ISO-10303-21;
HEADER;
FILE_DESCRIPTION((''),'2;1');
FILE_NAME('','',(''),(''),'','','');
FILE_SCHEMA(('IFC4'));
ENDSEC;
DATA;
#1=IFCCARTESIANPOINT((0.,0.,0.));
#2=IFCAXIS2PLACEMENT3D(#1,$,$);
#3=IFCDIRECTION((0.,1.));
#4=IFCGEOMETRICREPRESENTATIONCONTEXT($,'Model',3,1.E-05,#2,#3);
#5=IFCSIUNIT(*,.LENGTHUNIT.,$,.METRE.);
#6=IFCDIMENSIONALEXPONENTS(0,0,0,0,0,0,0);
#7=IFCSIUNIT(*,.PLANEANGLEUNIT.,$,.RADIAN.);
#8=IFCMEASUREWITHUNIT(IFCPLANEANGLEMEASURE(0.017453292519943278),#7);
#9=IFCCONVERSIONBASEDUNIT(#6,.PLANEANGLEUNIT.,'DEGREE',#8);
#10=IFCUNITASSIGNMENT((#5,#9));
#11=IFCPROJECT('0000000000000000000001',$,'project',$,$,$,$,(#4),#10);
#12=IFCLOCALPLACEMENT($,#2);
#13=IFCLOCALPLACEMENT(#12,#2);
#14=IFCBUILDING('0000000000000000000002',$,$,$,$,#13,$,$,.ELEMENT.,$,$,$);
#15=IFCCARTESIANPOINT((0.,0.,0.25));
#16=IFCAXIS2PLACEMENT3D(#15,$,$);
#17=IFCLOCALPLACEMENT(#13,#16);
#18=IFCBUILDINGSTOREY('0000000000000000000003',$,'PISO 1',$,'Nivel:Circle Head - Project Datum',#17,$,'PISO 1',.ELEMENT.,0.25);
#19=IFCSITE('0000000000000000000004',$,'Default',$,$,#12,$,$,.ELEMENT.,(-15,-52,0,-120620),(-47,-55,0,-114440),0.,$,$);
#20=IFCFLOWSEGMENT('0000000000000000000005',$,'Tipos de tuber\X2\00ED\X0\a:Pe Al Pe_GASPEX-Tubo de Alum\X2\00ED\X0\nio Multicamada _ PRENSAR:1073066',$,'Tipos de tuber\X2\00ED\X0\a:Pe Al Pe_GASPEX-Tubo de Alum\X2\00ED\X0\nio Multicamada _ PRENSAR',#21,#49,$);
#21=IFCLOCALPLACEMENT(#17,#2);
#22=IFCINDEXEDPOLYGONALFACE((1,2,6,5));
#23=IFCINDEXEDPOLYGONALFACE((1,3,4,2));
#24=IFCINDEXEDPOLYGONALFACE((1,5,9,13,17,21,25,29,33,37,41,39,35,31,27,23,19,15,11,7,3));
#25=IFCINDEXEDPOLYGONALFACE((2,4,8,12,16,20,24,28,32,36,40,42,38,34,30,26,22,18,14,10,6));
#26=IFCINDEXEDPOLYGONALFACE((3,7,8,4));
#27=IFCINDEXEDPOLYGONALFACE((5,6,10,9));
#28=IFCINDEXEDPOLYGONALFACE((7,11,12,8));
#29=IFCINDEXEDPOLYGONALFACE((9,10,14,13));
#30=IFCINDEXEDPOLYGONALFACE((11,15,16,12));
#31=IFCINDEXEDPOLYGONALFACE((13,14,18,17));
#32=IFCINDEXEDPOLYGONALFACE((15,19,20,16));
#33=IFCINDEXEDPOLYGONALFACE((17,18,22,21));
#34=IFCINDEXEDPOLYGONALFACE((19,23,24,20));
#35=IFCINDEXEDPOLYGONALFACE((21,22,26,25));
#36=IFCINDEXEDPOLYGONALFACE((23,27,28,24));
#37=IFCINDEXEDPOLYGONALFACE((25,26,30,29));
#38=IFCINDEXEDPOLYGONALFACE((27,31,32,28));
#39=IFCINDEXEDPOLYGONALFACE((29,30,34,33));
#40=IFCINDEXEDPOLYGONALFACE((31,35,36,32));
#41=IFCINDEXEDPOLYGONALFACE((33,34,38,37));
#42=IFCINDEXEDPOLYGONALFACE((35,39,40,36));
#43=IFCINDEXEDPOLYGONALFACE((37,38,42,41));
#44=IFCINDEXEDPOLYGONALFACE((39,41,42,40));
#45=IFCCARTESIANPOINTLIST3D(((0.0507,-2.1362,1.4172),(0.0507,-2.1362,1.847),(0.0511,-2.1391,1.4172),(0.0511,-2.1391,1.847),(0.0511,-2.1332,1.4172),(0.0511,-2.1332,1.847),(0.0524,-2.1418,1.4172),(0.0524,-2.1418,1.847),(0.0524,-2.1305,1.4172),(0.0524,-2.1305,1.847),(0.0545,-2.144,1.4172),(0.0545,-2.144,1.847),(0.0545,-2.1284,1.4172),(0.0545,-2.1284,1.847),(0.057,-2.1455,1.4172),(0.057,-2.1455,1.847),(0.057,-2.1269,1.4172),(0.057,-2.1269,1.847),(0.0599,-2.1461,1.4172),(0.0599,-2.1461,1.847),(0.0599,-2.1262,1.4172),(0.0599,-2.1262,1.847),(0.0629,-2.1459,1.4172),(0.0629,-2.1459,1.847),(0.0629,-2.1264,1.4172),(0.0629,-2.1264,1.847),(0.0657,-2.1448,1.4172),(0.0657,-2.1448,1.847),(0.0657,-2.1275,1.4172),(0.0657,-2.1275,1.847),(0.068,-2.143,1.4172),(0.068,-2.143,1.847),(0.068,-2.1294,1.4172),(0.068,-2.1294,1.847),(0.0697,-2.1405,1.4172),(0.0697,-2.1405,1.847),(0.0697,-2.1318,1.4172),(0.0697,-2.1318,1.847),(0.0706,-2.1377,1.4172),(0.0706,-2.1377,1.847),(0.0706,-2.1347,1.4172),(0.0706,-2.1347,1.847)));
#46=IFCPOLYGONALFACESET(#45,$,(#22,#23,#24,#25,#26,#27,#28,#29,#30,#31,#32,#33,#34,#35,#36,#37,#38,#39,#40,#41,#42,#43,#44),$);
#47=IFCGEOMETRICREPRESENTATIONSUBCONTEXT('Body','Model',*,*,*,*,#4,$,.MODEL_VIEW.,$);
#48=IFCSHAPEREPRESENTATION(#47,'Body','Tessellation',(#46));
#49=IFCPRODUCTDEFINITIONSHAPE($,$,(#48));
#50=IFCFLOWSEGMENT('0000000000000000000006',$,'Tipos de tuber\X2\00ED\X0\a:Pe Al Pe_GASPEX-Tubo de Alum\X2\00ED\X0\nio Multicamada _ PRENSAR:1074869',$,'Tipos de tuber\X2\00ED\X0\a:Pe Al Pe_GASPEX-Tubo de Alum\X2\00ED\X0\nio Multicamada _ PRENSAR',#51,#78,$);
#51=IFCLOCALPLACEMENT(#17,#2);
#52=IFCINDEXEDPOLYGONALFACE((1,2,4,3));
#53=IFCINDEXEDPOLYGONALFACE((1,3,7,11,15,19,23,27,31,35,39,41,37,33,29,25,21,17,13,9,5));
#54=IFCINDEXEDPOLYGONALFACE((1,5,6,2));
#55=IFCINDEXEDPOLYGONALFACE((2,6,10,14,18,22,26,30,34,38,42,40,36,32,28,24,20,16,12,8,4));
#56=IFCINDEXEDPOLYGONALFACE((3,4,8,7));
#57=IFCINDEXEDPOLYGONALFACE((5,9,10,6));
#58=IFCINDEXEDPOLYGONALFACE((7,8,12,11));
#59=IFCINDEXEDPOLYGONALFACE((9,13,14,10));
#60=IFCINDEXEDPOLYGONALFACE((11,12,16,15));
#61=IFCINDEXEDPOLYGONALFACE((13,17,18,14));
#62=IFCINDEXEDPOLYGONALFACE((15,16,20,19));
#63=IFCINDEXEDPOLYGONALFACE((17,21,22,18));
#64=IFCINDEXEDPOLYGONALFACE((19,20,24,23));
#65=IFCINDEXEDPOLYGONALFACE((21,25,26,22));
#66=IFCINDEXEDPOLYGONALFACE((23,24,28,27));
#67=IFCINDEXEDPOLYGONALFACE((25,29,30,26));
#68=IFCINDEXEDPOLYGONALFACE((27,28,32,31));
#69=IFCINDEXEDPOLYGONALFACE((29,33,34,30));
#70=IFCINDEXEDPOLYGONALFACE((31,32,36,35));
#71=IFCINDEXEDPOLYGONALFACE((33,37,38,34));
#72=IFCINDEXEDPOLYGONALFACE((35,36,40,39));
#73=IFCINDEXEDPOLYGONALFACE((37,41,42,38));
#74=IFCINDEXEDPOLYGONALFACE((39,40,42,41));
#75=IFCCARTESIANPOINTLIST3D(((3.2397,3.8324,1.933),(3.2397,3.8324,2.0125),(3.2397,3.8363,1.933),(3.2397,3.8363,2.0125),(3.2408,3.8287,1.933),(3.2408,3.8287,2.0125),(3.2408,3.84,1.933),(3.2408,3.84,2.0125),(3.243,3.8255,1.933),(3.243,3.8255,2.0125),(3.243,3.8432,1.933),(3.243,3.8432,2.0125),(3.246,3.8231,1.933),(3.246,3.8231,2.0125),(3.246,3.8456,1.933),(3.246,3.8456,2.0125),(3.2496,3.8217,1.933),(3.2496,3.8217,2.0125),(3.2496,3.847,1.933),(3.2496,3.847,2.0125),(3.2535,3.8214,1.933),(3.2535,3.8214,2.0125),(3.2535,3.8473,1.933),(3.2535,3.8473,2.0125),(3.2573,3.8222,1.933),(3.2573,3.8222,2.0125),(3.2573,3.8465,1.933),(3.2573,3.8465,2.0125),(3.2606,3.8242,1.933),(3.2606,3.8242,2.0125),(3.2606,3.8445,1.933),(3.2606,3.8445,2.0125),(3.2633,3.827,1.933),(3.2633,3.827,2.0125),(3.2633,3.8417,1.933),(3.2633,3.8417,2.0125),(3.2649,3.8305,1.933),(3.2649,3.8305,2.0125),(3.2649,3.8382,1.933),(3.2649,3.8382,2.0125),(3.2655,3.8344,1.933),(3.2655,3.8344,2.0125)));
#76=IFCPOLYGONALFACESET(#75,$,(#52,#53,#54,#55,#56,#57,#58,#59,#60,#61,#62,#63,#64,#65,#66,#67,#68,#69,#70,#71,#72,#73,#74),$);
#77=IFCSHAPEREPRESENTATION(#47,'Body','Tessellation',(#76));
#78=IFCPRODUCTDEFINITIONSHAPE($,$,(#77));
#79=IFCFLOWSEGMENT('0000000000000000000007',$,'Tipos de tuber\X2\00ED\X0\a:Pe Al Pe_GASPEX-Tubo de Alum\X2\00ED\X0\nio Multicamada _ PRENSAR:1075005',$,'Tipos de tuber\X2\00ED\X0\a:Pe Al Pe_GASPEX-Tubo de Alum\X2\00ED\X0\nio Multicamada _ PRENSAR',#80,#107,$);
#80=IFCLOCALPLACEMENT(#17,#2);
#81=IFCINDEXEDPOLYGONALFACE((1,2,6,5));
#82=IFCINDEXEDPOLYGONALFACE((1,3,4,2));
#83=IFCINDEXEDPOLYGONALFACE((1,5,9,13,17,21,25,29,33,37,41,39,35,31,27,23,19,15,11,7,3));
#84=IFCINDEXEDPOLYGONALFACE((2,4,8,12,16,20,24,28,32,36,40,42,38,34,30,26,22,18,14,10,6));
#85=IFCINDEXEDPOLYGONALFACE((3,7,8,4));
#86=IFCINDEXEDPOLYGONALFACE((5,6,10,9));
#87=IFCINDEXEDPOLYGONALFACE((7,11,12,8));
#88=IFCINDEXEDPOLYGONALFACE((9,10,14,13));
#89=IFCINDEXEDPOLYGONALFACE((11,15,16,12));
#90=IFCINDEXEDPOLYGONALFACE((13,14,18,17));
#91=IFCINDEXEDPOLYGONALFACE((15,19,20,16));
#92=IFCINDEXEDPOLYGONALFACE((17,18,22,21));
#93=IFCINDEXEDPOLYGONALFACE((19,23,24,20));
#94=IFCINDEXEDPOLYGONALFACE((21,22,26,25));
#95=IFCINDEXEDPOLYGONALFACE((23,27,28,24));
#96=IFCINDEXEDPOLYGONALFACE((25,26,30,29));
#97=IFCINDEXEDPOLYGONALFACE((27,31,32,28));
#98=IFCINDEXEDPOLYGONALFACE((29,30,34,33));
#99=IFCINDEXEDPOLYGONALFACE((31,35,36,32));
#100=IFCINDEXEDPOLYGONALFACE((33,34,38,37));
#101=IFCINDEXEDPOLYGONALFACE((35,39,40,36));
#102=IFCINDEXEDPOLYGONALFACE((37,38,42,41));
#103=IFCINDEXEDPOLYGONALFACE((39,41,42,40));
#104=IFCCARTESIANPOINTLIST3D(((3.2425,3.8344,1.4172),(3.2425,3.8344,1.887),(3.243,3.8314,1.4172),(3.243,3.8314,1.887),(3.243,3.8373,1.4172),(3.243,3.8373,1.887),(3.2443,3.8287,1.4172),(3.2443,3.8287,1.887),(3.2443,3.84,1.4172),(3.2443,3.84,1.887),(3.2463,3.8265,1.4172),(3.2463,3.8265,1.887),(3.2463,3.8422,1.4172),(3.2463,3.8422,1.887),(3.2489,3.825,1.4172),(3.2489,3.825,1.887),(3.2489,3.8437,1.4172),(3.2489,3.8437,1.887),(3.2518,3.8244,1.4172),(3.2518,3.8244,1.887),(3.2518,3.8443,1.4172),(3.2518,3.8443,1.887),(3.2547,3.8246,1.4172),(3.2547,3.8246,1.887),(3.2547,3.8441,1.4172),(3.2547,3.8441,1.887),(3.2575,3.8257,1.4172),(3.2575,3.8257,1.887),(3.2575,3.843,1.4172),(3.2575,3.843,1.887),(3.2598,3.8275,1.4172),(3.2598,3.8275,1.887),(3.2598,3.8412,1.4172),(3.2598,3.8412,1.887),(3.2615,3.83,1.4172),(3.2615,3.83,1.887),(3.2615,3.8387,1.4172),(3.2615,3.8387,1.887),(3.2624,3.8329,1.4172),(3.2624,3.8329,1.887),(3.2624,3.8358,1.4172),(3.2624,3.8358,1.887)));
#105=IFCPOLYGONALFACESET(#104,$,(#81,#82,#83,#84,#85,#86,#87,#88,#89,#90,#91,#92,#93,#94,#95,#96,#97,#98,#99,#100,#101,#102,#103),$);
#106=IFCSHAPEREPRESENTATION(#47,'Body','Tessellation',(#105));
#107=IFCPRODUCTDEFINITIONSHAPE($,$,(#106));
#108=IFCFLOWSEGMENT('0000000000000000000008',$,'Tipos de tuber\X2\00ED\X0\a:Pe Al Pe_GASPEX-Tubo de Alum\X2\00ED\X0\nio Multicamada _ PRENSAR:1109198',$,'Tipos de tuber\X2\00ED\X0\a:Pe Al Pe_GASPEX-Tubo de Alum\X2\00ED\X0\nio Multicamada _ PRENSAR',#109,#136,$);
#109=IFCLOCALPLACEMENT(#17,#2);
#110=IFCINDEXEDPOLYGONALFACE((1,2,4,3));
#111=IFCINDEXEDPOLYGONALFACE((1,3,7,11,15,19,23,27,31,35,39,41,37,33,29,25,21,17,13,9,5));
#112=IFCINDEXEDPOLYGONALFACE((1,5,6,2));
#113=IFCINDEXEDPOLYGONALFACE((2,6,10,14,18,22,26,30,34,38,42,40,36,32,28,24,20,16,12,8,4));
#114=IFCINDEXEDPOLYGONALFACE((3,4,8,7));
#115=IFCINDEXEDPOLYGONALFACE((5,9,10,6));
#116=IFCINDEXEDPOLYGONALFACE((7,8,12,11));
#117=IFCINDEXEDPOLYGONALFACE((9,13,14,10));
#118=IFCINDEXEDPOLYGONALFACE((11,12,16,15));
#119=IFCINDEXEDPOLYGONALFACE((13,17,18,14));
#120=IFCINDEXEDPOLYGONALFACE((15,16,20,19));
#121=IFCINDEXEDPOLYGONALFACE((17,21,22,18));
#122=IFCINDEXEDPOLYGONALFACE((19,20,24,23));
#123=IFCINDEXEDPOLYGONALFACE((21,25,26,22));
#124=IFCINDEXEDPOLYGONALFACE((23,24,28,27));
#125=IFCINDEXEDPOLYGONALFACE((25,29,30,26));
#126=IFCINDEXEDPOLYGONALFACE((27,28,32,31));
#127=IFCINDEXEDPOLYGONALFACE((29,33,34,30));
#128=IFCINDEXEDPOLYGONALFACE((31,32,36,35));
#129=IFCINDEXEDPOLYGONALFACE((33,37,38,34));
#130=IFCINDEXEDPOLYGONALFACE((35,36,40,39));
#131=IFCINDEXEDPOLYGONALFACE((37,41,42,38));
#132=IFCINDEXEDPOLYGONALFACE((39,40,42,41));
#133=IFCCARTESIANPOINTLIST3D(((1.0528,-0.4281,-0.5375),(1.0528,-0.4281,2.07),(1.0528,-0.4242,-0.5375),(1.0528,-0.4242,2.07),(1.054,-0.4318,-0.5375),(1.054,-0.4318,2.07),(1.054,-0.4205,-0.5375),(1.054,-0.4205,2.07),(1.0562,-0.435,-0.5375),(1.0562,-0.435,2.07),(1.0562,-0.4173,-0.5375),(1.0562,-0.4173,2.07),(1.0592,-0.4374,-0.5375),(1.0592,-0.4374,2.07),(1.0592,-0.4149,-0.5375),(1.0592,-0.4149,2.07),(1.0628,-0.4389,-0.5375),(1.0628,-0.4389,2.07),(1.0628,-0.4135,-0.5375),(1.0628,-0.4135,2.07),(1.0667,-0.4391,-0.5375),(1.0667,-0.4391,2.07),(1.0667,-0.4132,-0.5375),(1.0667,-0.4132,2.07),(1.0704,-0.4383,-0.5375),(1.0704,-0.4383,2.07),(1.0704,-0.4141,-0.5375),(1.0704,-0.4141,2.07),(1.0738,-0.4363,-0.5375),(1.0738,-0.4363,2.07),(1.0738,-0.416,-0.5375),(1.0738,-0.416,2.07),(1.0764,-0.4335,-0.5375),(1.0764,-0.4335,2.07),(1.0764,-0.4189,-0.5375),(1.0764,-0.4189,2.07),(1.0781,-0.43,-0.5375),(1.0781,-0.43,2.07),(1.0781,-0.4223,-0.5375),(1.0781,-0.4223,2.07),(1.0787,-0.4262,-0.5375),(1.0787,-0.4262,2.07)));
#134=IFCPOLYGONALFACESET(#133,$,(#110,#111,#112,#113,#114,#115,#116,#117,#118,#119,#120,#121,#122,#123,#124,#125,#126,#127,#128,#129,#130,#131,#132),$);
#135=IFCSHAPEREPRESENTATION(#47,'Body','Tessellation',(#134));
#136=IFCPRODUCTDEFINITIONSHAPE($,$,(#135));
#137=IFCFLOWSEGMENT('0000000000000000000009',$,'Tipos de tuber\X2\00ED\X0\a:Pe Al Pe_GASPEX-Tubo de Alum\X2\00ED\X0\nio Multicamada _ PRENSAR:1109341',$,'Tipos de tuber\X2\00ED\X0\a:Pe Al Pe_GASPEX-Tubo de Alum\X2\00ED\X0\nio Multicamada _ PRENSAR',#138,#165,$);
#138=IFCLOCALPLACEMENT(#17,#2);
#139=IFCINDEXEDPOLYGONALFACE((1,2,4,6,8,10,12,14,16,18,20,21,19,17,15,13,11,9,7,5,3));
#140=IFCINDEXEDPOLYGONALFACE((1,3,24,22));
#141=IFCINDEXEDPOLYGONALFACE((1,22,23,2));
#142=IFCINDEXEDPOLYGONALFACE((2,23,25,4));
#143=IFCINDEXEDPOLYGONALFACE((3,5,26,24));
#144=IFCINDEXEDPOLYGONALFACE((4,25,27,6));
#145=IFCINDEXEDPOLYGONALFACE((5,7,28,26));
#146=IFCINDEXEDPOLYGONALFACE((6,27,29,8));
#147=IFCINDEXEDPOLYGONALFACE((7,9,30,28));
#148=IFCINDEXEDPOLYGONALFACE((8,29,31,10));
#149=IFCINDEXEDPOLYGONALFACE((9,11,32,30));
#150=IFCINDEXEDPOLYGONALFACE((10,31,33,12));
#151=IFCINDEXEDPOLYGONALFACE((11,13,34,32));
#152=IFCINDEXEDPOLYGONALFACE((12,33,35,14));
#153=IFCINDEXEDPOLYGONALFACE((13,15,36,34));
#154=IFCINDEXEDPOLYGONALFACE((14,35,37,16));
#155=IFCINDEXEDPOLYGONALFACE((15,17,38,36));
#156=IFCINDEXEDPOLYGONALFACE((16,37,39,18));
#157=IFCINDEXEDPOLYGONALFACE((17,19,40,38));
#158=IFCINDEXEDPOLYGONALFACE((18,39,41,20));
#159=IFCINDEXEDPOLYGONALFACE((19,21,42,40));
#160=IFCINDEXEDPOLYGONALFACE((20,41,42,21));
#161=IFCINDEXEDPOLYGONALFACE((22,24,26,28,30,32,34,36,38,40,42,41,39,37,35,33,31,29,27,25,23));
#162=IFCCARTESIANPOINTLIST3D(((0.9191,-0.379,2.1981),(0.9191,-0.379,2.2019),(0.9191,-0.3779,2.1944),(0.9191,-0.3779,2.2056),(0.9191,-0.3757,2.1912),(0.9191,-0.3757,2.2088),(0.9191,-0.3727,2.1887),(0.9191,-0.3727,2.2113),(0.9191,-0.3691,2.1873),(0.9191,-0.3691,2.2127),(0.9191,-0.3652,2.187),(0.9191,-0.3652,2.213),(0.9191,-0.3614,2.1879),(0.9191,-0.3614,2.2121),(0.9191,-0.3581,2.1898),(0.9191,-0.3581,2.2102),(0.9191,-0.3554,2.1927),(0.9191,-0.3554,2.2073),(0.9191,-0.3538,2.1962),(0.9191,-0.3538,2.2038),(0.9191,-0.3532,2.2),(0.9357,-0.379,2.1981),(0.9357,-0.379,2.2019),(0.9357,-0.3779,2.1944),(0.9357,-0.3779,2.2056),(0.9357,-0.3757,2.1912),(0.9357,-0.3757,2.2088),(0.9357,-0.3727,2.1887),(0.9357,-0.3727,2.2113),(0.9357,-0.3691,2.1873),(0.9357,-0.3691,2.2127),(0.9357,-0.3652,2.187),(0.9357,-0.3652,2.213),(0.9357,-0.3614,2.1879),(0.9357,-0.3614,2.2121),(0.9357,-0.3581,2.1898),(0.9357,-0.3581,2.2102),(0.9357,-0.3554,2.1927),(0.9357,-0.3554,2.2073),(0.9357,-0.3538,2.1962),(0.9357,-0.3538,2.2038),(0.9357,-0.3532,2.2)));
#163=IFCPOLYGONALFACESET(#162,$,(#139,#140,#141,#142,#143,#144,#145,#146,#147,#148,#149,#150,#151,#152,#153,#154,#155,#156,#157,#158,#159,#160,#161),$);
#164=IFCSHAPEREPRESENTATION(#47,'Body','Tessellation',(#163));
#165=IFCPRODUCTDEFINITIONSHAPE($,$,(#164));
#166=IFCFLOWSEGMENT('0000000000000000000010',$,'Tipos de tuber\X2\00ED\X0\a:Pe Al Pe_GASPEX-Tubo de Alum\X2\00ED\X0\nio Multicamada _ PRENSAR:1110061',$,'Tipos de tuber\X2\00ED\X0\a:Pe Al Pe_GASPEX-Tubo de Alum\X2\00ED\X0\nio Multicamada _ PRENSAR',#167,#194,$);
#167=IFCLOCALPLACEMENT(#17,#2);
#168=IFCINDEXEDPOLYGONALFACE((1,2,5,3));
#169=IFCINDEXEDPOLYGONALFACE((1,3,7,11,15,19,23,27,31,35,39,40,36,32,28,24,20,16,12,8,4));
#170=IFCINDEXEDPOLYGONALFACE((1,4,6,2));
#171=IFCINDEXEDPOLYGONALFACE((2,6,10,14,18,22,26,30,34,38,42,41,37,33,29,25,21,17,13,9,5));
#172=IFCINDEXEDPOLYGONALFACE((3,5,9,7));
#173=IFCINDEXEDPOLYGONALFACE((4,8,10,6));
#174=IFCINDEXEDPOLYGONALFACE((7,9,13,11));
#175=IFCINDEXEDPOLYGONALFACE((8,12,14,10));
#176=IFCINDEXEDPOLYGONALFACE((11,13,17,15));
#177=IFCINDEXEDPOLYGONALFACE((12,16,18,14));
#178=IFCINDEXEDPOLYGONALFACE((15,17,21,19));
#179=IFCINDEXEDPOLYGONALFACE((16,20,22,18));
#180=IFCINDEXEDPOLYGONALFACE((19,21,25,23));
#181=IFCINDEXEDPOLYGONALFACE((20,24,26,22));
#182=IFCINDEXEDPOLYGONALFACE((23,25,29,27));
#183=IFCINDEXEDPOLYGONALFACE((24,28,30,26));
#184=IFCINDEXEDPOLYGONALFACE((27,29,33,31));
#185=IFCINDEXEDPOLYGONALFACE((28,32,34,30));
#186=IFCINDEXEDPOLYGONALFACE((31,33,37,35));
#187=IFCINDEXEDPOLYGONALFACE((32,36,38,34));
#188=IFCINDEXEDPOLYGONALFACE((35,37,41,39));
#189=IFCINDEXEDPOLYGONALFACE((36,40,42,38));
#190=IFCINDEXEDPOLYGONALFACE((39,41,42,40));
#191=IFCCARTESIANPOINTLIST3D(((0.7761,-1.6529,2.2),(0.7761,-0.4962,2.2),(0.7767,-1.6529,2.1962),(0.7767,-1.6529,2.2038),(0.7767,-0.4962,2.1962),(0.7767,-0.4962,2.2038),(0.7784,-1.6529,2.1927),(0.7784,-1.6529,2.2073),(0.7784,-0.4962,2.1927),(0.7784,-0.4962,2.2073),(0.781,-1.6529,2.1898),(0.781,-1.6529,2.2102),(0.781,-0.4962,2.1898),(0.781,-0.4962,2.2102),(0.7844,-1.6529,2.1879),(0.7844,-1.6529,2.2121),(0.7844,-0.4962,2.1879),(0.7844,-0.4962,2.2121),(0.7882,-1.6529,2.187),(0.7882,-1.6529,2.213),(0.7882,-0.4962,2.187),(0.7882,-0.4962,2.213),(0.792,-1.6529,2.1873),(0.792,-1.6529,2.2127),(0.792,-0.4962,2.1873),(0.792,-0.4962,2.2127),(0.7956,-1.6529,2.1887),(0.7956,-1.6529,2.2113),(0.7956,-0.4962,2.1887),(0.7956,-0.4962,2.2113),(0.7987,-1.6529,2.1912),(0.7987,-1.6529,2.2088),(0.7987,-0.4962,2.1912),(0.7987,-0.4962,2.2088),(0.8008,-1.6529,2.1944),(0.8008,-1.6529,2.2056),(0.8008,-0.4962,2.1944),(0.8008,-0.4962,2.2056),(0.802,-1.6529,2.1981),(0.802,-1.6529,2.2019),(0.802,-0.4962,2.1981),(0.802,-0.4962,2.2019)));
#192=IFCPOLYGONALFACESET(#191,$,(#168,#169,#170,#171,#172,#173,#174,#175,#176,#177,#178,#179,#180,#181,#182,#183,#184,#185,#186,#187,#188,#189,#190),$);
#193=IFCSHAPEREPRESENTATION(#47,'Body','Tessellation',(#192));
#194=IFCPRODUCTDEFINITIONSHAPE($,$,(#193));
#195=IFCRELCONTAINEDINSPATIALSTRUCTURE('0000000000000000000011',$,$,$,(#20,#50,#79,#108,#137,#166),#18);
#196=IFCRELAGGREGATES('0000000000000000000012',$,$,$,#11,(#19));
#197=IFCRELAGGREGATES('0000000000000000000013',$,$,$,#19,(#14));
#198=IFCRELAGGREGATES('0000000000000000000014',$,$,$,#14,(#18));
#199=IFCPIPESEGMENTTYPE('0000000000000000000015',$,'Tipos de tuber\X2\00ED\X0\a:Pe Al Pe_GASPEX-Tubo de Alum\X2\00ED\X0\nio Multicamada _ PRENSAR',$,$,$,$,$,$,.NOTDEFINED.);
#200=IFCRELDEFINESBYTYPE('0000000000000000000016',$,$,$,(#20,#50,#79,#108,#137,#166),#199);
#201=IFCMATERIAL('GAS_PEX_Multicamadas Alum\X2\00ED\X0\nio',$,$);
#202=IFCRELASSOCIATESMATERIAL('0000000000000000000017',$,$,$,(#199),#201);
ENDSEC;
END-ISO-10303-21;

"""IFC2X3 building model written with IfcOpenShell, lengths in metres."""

from ifc_helpers import new_model, entity, si_unit, converted_unit, direction, frame, frame_2d, origin, origin_2d_with_axis, place, context, subcontext, project, spatial, circle, extrude, material, type_object, element, save


model = new_model("IFC2X3")

# Units and contexts
model_context = context("Model", 3, precision=1e-05, world=origin(), true_north=direction((0.0, 1.0)))
body_context = subcontext(model_context, "Body", "Model", "MODEL_VIEW")
ifc_project = project(units=[si_unit("LENGTHUNIT", "METRE"), converted_unit("PLANEANGLEUNIT", "DEGREE", entity("IfcPlaneAngleMeasure", 0.017453292519943278), si_unit("PLANEANGLEUNIT", "RADIAN"), dimensions=[0, 0, 0, 0, 0, 0, 0])], contexts=[model_context])

# Site, building, storey
site_placement = place(None, origin())
site = spatial("IfcSite", under=ifc_project, at=site_placement, Name="Default", CompositionType="ELEMENT", RefLatitude=(-15, -52, 0, -120620), RefLongitude=(-47, -55, 0, -114440), RefElevation=0.0)
building_placement = place(site_placement, origin())
building = spatial("IfcBuilding", under=site, at=building_placement, CompositionType="ELEMENT")
storey_placement = place(building_placement, frame((0.0, 0.0, 0.25)))
storey = spatial("IfcBuildingStorey", under=building, at=storey_placement, Name="PISO 1", ObjectType="Nivel:Circle Head - Project Datum", LongName="PISO 1", CompositionType="ELEMENT", Elevation=0.25)

# Flow segments
ifc_material = material(Name="GAS_PEX_Multicamadas Alumínio")
pipe_segment_type = type_object("IfcPipeSegmentType", Name="Tipos de tubería:Pe Al Pe_GASPEX-Tubo de Alumínio Multicamada _ PRENSAR", PredefinedType="NOTDEFINED", material=ifc_material)
flow_segment_1_placement = place(storey_placement, origin())
element("IfcFlowSegment", 1, at=flow_segment_1_placement, inside=storey, type_object=pipe_segment_type, Name="Tipos de tubería:Pe Al Pe_GASPEX-Tubo de Alumínio Multicamada _ PRENSAR:1073066", ObjectType="Tipos de tubería:Pe Al Pe_GASPEX-Tubo de Alumínio Multicamada _ PRENSAR", context=body_context, shape_type="SweptSolid", body=[
    extrude(circle(Radius=0.01, at=frame_2d((0.0, 0.0), x_axis=(1.0, 0.0))), frame((0.0607, -2.1362, 1.4172), z_axis=(0.0, 0.0, 1.0), x_axis=(-1.0, 0.0, 0.0)), (0.0, 0.0, 1.0), 0.4298),
])
flow_segment_2_placement = place(storey_placement, origin())
element("IfcFlowSegment", 2, at=flow_segment_2_placement, inside=storey, type_object=pipe_segment_type, Name="Tipos de tubería:Pe Al Pe_GASPEX-Tubo de Alumínio Multicamada _ PRENSAR:1074869", ObjectType="Tipos de tubería:Pe Al Pe_GASPEX-Tubo de Alumínio Multicamada _ PRENSAR", context=body_context, shape_type="SweptSolid", body=[
    extrude(circle(Radius=0.013, at=frame_2d((0.0, 0.0), x_axis=(1.0, 0.0))), frame((3.2525, 3.8344, 1.933)), (0.0, 0.0, 1.0), 0.0795),
])
flow_segment_3_placement = place(storey_placement, origin())
element("IfcFlowSegment", 3, at=flow_segment_3_placement, inside=storey, type_object=pipe_segment_type, Name="Tipos de tubería:Pe Al Pe_GASPEX-Tubo de Alumínio Multicamada _ PRENSAR:1075005", ObjectType="Tipos de tubería:Pe Al Pe_GASPEX-Tubo de Alumínio Multicamada _ PRENSAR", context=body_context, shape_type="SweptSolid", body=[
    extrude(circle(Radius=0.01, at=origin_2d_with_axis()), frame((3.2525, 3.8344, 1.4172), z_axis=(0.0, 0.0, 1.0), x_axis=(-1.0, 0.0, 0.0)), (0.0, 0.0, 1.0), 0.4698),
])
flow_segment_4_placement = place(storey_placement, origin())
element("IfcFlowSegment", 4, at=flow_segment_4_placement, inside=storey, type_object=pipe_segment_type, Name="Tipos de tubería:Pe Al Pe_GASPEX-Tubo de Alumínio Multicamada _ PRENSAR:1109198", ObjectType="Tipos de tubería:Pe Al Pe_GASPEX-Tubo de Alumínio Multicamada _ PRENSAR", context=body_context, shape_type="SweptSolid", body=[
    extrude(circle(Radius=0.013, at=origin_2d_with_axis()), frame((1.0657, -0.4262, -0.5375)), (0.0, 0.0, 1.0), 2.6075),
])
flow_segment_5_placement = place(storey_placement, origin())
element("IfcFlowSegment", 5, at=flow_segment_5_placement, inside=storey, type_object=pipe_segment_type, Name="Tipos de tubería:Pe Al Pe_GASPEX-Tubo de Alumínio Multicamada _ PRENSAR:1109341", ObjectType="Tipos de tubería:Pe Al Pe_GASPEX-Tubo de Alumínio Multicamada _ PRENSAR", context=body_context, shape_type="SweptSolid", body=[
    extrude(circle(Radius=0.013, at=frame_2d((0.0, 0.0), x_axis=(1.0, 0.0))), frame((0.9191, -0.3662, 2.2), z_axis=(1.0, 0.0, 0.0), x_axis=(0.0, 1.0, 0.0)), (0.0, 0.0, 1.0), 0.0166),
])
flow_segment_6_placement = place(storey_placement, origin())
element("IfcFlowSegment", 6, at=flow_segment_6_placement, inside=storey, type_object=pipe_segment_type, Name="Tipos de tubería:Pe Al Pe_GASPEX-Tubo de Alumínio Multicamada _ PRENSAR:1110061", ObjectType="Tipos de tubería:Pe Al Pe_GASPEX-Tubo de Alumínio Multicamada _ PRENSAR", context=body_context, shape_type="SweptSolid", body=[
    extrude(circle(Radius=0.013, at=frame_2d((0.0, 0.0), x_axis=(1.0, 0.0))), frame((0.7891, -1.6529, 2.2), z_axis=(0.0, 1.0, 0.0), x_axis=(-1.0, 0.0, 0.0)), (0.0, 0.0, 1.0), 1.1567),
])

save(model, "model.ifc")
